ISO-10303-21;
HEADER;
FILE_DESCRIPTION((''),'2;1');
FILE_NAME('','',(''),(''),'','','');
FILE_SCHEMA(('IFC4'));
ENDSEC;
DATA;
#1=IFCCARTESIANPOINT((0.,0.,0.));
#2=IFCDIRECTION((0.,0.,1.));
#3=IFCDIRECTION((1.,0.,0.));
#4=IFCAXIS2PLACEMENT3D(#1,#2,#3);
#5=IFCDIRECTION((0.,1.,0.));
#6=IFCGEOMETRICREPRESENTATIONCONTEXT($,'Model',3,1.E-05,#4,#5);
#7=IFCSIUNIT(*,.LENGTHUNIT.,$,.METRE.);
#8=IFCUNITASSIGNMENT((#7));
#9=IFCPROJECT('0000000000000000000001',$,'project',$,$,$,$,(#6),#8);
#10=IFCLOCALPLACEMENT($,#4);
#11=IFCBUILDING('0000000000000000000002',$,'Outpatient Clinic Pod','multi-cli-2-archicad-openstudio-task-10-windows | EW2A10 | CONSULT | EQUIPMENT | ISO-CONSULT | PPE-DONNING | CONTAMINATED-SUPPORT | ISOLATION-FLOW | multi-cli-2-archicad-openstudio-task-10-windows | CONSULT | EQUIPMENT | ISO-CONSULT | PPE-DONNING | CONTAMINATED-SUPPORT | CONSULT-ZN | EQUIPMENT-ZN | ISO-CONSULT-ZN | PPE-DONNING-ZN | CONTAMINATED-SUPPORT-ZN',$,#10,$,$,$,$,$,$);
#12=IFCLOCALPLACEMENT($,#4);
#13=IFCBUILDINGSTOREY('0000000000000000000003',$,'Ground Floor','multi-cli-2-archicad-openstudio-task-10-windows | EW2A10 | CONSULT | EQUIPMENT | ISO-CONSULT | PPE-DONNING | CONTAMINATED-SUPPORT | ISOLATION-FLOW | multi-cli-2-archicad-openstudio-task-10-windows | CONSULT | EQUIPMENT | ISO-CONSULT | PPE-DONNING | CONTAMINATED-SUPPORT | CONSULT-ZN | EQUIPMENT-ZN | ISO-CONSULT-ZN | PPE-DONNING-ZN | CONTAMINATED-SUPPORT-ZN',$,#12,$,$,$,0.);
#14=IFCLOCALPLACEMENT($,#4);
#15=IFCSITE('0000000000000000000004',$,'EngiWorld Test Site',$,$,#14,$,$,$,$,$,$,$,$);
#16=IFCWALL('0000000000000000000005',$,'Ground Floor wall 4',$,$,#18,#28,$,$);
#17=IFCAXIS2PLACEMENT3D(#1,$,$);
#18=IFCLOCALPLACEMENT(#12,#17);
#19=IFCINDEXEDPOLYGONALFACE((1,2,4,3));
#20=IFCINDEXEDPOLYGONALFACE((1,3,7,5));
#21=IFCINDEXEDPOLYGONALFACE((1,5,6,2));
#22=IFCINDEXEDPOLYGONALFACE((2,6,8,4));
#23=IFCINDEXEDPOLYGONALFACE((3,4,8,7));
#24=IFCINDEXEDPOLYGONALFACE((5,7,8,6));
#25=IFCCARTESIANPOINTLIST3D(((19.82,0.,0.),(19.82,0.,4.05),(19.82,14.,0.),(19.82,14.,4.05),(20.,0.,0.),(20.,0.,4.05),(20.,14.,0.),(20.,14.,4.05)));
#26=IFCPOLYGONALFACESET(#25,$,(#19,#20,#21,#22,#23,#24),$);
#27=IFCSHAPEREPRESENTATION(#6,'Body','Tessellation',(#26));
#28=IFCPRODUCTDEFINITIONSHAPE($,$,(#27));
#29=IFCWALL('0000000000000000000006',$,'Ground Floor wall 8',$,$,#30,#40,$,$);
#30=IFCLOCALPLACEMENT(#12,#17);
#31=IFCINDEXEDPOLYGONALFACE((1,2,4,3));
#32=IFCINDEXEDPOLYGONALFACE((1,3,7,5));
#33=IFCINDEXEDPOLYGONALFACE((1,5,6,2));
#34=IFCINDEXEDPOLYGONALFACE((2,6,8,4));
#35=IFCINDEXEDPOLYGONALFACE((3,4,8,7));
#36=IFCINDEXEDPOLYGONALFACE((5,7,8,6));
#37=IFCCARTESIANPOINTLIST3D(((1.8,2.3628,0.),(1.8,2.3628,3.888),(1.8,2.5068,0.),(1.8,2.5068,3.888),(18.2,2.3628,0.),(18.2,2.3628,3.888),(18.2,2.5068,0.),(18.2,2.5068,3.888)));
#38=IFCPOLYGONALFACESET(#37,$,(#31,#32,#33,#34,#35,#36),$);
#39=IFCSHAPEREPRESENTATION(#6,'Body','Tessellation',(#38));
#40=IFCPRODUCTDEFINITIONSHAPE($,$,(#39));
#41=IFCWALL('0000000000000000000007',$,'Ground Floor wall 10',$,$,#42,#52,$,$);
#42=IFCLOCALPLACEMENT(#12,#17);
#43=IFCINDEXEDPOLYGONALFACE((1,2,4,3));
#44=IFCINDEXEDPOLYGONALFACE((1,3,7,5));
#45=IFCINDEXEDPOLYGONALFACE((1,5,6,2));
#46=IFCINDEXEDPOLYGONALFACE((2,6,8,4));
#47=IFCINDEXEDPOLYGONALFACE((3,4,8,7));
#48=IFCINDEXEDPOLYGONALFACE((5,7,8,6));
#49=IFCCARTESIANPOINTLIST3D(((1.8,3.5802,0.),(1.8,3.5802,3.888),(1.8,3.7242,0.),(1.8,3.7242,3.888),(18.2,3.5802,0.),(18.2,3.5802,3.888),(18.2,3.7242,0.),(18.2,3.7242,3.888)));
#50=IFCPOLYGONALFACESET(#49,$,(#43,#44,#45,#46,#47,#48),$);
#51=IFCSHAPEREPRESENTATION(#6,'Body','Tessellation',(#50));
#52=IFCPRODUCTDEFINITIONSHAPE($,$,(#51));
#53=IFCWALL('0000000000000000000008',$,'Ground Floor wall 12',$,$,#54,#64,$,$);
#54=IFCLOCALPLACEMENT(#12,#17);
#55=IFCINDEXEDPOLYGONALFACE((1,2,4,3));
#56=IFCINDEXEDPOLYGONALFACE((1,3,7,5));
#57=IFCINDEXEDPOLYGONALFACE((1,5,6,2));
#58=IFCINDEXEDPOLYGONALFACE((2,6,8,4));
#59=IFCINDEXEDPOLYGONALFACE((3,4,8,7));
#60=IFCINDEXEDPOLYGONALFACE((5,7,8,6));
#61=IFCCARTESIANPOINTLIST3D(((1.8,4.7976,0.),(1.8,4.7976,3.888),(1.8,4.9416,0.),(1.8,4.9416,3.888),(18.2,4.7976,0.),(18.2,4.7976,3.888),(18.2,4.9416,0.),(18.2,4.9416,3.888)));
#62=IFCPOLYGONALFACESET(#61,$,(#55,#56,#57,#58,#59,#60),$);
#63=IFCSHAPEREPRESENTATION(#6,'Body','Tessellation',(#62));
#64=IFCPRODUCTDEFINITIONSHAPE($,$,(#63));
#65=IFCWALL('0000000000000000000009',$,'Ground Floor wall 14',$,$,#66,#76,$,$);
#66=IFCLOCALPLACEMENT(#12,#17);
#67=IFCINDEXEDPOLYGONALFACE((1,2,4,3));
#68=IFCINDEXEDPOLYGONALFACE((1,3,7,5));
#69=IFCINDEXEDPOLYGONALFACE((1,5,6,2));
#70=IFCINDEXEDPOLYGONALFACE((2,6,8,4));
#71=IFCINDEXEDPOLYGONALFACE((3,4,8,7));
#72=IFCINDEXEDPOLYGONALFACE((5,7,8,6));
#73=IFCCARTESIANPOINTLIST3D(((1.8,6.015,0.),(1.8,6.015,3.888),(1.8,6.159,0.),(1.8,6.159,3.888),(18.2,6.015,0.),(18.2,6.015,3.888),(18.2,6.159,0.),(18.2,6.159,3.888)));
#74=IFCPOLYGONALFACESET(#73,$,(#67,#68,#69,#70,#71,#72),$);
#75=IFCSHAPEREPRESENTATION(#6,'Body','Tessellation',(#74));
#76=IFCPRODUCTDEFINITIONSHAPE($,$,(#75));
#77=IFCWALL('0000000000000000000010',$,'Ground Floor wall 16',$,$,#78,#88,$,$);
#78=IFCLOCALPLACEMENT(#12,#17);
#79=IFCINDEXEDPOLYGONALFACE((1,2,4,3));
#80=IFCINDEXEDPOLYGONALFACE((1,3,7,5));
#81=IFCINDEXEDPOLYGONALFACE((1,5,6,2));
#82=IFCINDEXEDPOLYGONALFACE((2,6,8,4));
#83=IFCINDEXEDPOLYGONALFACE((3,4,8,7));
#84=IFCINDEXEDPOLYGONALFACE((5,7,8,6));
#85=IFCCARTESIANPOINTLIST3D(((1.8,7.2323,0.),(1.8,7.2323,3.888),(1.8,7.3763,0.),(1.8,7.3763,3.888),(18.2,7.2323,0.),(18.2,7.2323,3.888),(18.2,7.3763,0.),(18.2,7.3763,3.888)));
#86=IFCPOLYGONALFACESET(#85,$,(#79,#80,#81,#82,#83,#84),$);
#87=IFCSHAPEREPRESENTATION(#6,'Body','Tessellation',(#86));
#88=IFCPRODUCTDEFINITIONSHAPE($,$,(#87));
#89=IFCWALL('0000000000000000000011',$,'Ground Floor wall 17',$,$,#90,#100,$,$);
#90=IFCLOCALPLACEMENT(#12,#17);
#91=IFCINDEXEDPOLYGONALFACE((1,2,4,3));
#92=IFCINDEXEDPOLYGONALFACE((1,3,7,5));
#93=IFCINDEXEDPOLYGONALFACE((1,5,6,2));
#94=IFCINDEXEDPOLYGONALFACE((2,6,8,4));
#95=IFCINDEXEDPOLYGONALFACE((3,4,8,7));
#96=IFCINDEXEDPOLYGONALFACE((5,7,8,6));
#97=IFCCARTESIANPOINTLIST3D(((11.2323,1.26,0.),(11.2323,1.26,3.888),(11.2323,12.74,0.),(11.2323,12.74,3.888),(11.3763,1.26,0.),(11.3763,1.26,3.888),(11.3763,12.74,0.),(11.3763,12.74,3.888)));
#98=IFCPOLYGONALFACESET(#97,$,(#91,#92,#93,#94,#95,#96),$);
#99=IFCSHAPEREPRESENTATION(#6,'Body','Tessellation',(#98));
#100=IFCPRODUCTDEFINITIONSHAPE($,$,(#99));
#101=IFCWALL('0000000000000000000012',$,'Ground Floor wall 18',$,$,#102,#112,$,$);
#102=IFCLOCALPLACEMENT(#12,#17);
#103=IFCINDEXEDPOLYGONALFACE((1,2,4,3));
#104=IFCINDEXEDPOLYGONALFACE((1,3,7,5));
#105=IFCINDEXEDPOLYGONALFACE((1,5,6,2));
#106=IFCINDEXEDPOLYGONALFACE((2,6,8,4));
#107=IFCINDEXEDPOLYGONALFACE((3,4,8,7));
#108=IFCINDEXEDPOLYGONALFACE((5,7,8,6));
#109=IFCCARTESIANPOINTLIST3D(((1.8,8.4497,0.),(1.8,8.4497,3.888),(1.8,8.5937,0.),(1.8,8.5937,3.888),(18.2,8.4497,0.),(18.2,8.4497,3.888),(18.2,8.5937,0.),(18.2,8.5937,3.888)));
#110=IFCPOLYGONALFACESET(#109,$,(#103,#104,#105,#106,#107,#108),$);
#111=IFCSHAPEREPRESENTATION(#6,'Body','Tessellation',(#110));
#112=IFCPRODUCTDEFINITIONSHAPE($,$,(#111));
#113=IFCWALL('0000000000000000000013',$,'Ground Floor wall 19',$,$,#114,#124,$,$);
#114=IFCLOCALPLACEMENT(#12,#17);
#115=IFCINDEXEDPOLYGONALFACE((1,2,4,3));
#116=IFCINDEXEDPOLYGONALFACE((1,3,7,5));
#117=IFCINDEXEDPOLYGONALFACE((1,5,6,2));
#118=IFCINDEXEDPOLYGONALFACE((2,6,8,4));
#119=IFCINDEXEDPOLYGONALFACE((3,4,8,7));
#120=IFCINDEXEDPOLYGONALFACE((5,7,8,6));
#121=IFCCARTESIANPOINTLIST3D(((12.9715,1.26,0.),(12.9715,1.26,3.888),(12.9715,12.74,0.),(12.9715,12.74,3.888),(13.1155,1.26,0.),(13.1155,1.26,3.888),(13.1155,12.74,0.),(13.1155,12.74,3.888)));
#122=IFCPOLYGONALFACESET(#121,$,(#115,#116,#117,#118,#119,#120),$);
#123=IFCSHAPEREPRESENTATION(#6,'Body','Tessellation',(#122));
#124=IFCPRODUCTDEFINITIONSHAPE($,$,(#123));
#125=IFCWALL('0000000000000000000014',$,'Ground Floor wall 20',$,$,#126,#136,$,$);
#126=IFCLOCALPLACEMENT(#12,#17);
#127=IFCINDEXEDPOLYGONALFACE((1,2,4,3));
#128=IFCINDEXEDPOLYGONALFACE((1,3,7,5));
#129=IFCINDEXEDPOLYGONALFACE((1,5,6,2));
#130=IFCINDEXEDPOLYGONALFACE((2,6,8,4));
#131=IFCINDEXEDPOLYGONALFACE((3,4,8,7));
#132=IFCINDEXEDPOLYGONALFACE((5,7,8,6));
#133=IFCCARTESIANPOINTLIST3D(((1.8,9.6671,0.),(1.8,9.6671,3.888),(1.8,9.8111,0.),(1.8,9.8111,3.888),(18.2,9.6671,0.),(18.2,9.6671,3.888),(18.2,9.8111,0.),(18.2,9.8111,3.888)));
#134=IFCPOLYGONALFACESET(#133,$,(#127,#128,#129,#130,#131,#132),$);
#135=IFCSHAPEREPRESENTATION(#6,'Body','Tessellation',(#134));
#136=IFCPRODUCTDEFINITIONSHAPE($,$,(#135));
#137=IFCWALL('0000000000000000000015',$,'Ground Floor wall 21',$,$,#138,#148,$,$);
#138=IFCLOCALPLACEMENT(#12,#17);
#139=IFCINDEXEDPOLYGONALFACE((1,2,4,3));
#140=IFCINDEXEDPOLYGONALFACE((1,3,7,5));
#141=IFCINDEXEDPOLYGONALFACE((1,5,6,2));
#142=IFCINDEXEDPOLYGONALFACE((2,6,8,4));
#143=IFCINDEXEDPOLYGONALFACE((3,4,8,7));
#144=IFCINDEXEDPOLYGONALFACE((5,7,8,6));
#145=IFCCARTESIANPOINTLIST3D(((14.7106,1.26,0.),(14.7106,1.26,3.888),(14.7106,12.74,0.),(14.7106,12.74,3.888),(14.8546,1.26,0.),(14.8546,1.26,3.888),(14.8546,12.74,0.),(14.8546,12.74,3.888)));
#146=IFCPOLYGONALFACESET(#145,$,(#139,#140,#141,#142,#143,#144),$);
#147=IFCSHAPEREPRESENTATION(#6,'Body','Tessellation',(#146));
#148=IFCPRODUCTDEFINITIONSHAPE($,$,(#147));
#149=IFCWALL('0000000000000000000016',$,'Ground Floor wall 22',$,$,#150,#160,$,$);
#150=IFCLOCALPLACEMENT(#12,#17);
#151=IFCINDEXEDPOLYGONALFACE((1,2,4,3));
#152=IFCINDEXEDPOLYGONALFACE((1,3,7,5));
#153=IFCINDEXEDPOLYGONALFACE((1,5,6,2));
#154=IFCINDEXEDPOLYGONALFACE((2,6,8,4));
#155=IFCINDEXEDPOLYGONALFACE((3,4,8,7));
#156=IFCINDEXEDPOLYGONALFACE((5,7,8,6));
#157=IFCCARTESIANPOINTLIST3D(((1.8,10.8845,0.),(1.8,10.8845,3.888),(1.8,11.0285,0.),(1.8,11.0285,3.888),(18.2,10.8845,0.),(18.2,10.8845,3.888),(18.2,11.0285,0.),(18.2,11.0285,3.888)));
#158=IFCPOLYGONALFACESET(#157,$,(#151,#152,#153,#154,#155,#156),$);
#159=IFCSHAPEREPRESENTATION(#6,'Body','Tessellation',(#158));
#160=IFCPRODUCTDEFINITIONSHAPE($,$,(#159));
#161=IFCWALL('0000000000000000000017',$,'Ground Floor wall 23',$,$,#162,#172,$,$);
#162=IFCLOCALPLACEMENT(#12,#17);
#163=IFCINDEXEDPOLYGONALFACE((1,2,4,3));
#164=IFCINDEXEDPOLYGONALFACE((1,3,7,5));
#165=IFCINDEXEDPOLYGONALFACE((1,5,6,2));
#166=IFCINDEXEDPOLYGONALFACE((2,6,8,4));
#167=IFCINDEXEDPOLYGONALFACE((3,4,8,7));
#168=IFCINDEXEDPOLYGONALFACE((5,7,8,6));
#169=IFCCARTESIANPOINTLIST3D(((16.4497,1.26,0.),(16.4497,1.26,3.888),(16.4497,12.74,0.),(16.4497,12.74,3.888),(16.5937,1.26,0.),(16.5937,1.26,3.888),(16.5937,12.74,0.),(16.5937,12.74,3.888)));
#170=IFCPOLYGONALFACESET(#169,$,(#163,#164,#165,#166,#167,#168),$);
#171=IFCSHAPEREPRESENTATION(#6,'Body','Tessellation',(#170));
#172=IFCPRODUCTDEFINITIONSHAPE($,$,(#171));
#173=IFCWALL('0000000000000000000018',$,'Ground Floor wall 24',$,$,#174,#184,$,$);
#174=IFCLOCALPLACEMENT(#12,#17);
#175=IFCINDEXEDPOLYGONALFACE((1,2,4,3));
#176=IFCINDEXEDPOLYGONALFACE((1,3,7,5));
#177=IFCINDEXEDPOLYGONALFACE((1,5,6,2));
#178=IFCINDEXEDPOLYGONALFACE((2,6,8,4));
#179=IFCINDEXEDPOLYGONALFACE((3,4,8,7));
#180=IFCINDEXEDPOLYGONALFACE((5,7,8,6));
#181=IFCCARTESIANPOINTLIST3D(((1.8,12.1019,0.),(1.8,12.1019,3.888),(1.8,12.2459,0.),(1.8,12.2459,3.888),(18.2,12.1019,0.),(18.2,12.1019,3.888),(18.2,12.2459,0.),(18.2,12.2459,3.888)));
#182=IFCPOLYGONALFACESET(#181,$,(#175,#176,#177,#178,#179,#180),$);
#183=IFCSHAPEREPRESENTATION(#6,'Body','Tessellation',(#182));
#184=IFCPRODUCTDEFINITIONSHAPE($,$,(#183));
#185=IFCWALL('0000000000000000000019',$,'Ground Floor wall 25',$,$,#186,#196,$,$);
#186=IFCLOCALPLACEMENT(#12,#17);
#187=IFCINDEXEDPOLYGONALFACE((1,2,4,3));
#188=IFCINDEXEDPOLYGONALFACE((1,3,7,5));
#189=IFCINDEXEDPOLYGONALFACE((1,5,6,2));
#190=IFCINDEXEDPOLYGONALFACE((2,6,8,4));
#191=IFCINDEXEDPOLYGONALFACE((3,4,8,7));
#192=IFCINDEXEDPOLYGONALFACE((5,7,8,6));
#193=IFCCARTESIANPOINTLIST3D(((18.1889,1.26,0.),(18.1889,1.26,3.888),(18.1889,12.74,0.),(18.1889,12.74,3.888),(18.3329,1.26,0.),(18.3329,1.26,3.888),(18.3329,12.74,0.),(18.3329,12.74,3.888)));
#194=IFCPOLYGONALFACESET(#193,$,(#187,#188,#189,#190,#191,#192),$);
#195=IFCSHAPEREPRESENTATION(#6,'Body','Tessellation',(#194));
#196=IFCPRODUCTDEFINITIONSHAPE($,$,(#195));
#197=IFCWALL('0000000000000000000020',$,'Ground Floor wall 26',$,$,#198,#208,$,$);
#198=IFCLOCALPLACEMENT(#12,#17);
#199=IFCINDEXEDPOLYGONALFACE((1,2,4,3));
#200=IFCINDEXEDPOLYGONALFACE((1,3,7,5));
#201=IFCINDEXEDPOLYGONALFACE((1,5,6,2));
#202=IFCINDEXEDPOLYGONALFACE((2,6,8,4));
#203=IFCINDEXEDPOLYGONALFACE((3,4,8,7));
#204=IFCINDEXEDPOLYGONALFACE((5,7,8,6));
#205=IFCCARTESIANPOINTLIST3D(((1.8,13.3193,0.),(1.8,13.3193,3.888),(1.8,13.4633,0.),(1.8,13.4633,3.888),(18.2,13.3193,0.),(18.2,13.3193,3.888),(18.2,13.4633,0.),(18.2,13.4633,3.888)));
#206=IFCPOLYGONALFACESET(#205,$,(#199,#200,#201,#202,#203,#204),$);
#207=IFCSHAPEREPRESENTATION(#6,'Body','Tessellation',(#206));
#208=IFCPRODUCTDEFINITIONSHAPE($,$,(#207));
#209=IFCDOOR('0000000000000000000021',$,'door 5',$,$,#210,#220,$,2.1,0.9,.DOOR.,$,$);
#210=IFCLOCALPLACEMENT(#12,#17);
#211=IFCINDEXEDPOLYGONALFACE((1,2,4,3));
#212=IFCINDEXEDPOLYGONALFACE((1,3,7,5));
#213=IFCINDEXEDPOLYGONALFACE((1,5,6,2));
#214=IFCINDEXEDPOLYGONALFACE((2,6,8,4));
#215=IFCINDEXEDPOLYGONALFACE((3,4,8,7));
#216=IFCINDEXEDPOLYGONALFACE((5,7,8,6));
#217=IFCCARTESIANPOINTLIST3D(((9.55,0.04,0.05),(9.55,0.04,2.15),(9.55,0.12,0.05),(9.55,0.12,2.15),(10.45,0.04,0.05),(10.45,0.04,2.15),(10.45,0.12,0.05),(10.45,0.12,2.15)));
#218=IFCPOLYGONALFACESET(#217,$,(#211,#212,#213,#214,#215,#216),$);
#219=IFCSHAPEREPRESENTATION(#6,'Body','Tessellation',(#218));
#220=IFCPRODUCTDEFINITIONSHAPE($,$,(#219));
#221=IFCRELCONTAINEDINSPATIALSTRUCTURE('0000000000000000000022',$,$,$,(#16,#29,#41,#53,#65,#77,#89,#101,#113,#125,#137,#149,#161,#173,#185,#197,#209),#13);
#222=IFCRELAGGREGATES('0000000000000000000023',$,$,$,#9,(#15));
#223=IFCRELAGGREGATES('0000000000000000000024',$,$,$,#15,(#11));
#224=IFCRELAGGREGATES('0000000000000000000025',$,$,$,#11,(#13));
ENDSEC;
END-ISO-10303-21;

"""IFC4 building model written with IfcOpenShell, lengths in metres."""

from ifc_helpers import new_model, si_unit, direction, frame, origin_with_axes, origin_2d_with_axis, place, context, project, spatial, rectangle, extrude, element, save


model = new_model("IFC4")

# Units and contexts
model_context = context("Model", 3, precision=1e-05, world=origin_with_axes(), true_north=direction((0.0, 1.0, 0.0)))
ifc_project = project(units=[si_unit("LENGTHUNIT", "METRE")], contexts=[model_context])

# Site, building, storey
site_placement = place(None, origin_with_axes())
site = spatial("IfcSite", under=ifc_project, at=site_placement, Name="EngiWorld Test Site")
building_placement = place(None, origin_with_axes())
building = spatial("IfcBuilding", under=site, at=building_placement, Name="Outpatient Clinic Pod", Description="multi-cli-2-archicad-openstudio-task-10-windows | EW2A10 | CONSULT | EQUIPMENT | ISO-CONSULT | PPE-DONNING | CONTAMINATED-SUPPORT | ISOLATION-FLOW | multi-cli-2-archicad-openstudio-task-10-windows | CONSULT | EQUIPMENT | ISO-CONSULT | PPE-DONNING | CONTAMINATED-SUPPORT | CONSULT-ZN | EQUIPMENT-ZN | ISO-CONSULT-ZN | PPE-DONNING-ZN | CONTAMINATED-SUPPORT-ZN")
storey_placement = place(None, origin_with_axes())
storey = spatial("IfcBuildingStorey", under=building, at=storey_placement, Name="Ground Floor", Description="multi-cli-2-archicad-openstudio-task-10-windows | EW2A10 | CONSULT | EQUIPMENT | ISO-CONSULT | PPE-DONNING | CONTAMINATED-SUPPORT | ISOLATION-FLOW | multi-cli-2-archicad-openstudio-task-10-windows | CONSULT | EQUIPMENT | ISO-CONSULT | PPE-DONNING | CONTAMINATED-SUPPORT | CONSULT-ZN | EQUIPMENT-ZN | ISO-CONSULT-ZN | PPE-DONNING-ZN | CONTAMINATED-SUPPORT-ZN", Elevation=0.0)

# Walls
wall_1_placement = place(None, frame((19.91, 7.0, 0.0), z_axis=(0.0, 0.0, 1.0), x_axis=(1.0, 0.0, 0.0)))
element("IfcWall", 1, at=wall_1_placement, inside=storey, Name="Ground Floor wall 4", context=model_context, shape_type="SweptSolid", body=[
    extrude(rectangle(XDim=0.18, YDim=14.0, at=origin_2d_with_axis()), origin_with_axes(), (0.0, 0.0, 1.0), 4.05),
])
for number, where, z_axis, x_axis, name in (
    (2, (10.0, 2.4348, 0.0), (0.0, 0.0, 1.0), (1.0, 0.0, 0.0), "Ground Floor wall 8"),
    (3, (10.0, 3.6522, 0.0), (0.0, 0.0, 1.0), (1.0, 0.0, 0.0), "Ground Floor wall 10"),
    (4, (10.0, 4.8696, 0.0), (0.0, 0.0, 1.0), (1.0, 0.0, 0.0), "Ground Floor wall 12"),
    (5, (10.0, 6.087, 0.0), (0.0, 0.0, 1.0), (1.0, 0.0, 0.0), "Ground Floor wall 14"),
    (6, (10.0, 7.3043, 0.0), (0.0, 0.0, 1.0), (1.0, 0.0, 0.0), "Ground Floor wall 16"),
):
    element("IfcWall", number, at=place(None, frame(where, z_axis=z_axis, x_axis=x_axis)), inside=storey, Name=name, context=model_context, shape_type="SweptSolid", body=[
        extrude(rectangle(XDim=16.4, YDim=0.144, at=origin_2d_with_axis()), origin_with_axes(), (0.0, 0.0, 1.0), 3.888),
    ])
wall_2_placement = place(None, frame((11.3043, 7.0, 0.0), z_axis=(0.0, 0.0, 1.0), x_axis=(1.0, 0.0, 0.0)))
element("IfcWall", 7, at=wall_2_placement, inside=storey, Name="Ground Floor wall 17", context=model_context, shape_type="SweptSolid", body=[
    extrude(rectangle(XDim=0.144, YDim=11.48, at=origin_2d_with_axis()), origin_with_axes(), (0.0, 0.0, 1.0), 3.888),
])
wall_3_placement = place(None, frame((10.0, 8.5217, 0.0), z_axis=(0.0, 0.0, 1.0), x_axis=(1.0, 0.0, 0.0)))
element("IfcWall", 8, at=wall_3_placement, inside=storey, Name="Ground Floor wall 18", context=model_context, shape_type="SweptSolid", body=[
    extrude(rectangle(XDim=16.4, YDim=0.144, at=origin_2d_with_axis()), origin_with_axes(), (0.0, 0.0, 1.0), 3.888),
])
wall_4_placement = place(None, frame((13.0435, 7.0, 0.0), z_axis=(0.0, 0.0, 1.0), x_axis=(1.0, 0.0, 0.0)))
element("IfcWall", 9, at=wall_4_placement, inside=storey, Name="Ground Floor wall 19", context=model_context, shape_type="SweptSolid", body=[
    extrude(rectangle(XDim=0.144, YDim=11.48, at=origin_2d_with_axis()), origin_with_axes(), (0.0, 0.0, 1.0), 3.888),
])
wall_5_placement = place(None, frame((10.0, 9.7391, 0.0), z_axis=(0.0, 0.0, 1.0), x_axis=(1.0, 0.0, 0.0)))
element("IfcWall", 10, at=wall_5_placement, inside=storey, Name="Ground Floor wall 20", context=model_context, shape_type="SweptSolid", body=[
    extrude(rectangle(XDim=16.4, YDim=0.144, at=origin_2d_with_axis()), origin_with_axes(), (0.0, 0.0, 1.0), 3.888),
])
wall_6_placement = place(None, frame((14.7826, 7.0, 0.0), z_axis=(0.0, 0.0, 1.0), x_axis=(1.0, 0.0, 0.0)))
element("IfcWall", 11, at=wall_6_placement, inside=storey, Name="Ground Floor wall 21", context=model_context, shape_type="SweptSolid", body=[
    extrude(rectangle(XDim=0.144, YDim=11.48, at=origin_2d_with_axis()), origin_with_axes(), (0.0, 0.0, 1.0), 3.888),
])
wall_7_placement = place(None, frame((10.0, 10.9565, 0.0), z_axis=(0.0, 0.0, 1.0), x_axis=(1.0, 0.0, 0.0)))
element("IfcWall", 12, at=wall_7_placement, inside=storey, Name="Ground Floor wall 22", context=model_context, shape_type="SweptSolid", body=[
    extrude(rectangle(XDim=16.4, YDim=0.144, at=origin_2d_with_axis()), origin_with_axes(), (0.0, 0.0, 1.0), 3.888),
])
wall_8_placement = place(None, frame((16.5217, 7.0, 0.0), z_axis=(0.0, 0.0, 1.0), x_axis=(1.0, 0.0, 0.0)))
element("IfcWall", 13, at=wall_8_placement, inside=storey, Name="Ground Floor wall 23", context=model_context, shape_type="SweptSolid", body=[
    extrude(rectangle(XDim=0.144, YDim=11.48, at=origin_2d_with_axis()), origin_with_axes(), (0.0, 0.0, 1.0), 3.888),
])
wall_9_placement = place(None, frame((10.0, 12.1739, 0.0), z_axis=(0.0, 0.0, 1.0), x_axis=(1.0, 0.0, 0.0)))
element("IfcWall", 14, at=wall_9_placement, inside=storey, Name="Ground Floor wall 24", context=model_context, shape_type="SweptSolid", body=[
    extrude(rectangle(XDim=16.4, YDim=0.144, at=origin_2d_with_axis()), origin_with_axes(), (0.0, 0.0, 1.0), 3.888),
])
wall_10_placement = place(None, frame((18.2609, 7.0, 0.0), z_axis=(0.0, 0.0, 1.0), x_axis=(1.0, 0.0, 0.0)))
element("IfcWall", 15, at=wall_10_placement, inside=storey, Name="Ground Floor wall 25", context=model_context, shape_type="SweptSolid", body=[
    extrude(rectangle(XDim=0.144, YDim=11.48, at=origin_2d_with_axis()), origin_with_axes(), (0.0, 0.0, 1.0), 3.888),
])
wall_11_placement = place(None, frame((10.0, 13.3913, 0.0), z_axis=(0.0, 0.0, 1.0), x_axis=(1.0, 0.0, 0.0)))
element("IfcWall", 16, at=wall_11_placement, inside=storey, Name="Ground Floor wall 26", context=model_context, shape_type="SweptSolid", body=[
    extrude(rectangle(XDim=16.4, YDim=0.144, at=origin_2d_with_axis()), origin_with_axes(), (0.0, 0.0, 1.0), 3.888),
])

# Door
for number, where, z_axis, x_axis, name in (
    (17, (10.0, 0.08, 0.05), (0.0, 0.0, 1.0), (1.0, 0.0, 0.0), "door 5"),
):
    element("IfcDoor", number, at=place(None, frame(where, z_axis=z_axis, x_axis=x_axis)), inside=storey, Name=name, OverallHeight=2.1, OverallWidth=0.9, PredefinedType="DOOR", context=model_context, shape_type="SweptSolid", body=[
        extrude(rectangle(XDim=0.9, YDim=0.08, at=origin_2d_with_axis()), origin_with_axes(), (0.0, 0.0, 1.0), 2.1),
    ])

save(model, "model.ifc")
